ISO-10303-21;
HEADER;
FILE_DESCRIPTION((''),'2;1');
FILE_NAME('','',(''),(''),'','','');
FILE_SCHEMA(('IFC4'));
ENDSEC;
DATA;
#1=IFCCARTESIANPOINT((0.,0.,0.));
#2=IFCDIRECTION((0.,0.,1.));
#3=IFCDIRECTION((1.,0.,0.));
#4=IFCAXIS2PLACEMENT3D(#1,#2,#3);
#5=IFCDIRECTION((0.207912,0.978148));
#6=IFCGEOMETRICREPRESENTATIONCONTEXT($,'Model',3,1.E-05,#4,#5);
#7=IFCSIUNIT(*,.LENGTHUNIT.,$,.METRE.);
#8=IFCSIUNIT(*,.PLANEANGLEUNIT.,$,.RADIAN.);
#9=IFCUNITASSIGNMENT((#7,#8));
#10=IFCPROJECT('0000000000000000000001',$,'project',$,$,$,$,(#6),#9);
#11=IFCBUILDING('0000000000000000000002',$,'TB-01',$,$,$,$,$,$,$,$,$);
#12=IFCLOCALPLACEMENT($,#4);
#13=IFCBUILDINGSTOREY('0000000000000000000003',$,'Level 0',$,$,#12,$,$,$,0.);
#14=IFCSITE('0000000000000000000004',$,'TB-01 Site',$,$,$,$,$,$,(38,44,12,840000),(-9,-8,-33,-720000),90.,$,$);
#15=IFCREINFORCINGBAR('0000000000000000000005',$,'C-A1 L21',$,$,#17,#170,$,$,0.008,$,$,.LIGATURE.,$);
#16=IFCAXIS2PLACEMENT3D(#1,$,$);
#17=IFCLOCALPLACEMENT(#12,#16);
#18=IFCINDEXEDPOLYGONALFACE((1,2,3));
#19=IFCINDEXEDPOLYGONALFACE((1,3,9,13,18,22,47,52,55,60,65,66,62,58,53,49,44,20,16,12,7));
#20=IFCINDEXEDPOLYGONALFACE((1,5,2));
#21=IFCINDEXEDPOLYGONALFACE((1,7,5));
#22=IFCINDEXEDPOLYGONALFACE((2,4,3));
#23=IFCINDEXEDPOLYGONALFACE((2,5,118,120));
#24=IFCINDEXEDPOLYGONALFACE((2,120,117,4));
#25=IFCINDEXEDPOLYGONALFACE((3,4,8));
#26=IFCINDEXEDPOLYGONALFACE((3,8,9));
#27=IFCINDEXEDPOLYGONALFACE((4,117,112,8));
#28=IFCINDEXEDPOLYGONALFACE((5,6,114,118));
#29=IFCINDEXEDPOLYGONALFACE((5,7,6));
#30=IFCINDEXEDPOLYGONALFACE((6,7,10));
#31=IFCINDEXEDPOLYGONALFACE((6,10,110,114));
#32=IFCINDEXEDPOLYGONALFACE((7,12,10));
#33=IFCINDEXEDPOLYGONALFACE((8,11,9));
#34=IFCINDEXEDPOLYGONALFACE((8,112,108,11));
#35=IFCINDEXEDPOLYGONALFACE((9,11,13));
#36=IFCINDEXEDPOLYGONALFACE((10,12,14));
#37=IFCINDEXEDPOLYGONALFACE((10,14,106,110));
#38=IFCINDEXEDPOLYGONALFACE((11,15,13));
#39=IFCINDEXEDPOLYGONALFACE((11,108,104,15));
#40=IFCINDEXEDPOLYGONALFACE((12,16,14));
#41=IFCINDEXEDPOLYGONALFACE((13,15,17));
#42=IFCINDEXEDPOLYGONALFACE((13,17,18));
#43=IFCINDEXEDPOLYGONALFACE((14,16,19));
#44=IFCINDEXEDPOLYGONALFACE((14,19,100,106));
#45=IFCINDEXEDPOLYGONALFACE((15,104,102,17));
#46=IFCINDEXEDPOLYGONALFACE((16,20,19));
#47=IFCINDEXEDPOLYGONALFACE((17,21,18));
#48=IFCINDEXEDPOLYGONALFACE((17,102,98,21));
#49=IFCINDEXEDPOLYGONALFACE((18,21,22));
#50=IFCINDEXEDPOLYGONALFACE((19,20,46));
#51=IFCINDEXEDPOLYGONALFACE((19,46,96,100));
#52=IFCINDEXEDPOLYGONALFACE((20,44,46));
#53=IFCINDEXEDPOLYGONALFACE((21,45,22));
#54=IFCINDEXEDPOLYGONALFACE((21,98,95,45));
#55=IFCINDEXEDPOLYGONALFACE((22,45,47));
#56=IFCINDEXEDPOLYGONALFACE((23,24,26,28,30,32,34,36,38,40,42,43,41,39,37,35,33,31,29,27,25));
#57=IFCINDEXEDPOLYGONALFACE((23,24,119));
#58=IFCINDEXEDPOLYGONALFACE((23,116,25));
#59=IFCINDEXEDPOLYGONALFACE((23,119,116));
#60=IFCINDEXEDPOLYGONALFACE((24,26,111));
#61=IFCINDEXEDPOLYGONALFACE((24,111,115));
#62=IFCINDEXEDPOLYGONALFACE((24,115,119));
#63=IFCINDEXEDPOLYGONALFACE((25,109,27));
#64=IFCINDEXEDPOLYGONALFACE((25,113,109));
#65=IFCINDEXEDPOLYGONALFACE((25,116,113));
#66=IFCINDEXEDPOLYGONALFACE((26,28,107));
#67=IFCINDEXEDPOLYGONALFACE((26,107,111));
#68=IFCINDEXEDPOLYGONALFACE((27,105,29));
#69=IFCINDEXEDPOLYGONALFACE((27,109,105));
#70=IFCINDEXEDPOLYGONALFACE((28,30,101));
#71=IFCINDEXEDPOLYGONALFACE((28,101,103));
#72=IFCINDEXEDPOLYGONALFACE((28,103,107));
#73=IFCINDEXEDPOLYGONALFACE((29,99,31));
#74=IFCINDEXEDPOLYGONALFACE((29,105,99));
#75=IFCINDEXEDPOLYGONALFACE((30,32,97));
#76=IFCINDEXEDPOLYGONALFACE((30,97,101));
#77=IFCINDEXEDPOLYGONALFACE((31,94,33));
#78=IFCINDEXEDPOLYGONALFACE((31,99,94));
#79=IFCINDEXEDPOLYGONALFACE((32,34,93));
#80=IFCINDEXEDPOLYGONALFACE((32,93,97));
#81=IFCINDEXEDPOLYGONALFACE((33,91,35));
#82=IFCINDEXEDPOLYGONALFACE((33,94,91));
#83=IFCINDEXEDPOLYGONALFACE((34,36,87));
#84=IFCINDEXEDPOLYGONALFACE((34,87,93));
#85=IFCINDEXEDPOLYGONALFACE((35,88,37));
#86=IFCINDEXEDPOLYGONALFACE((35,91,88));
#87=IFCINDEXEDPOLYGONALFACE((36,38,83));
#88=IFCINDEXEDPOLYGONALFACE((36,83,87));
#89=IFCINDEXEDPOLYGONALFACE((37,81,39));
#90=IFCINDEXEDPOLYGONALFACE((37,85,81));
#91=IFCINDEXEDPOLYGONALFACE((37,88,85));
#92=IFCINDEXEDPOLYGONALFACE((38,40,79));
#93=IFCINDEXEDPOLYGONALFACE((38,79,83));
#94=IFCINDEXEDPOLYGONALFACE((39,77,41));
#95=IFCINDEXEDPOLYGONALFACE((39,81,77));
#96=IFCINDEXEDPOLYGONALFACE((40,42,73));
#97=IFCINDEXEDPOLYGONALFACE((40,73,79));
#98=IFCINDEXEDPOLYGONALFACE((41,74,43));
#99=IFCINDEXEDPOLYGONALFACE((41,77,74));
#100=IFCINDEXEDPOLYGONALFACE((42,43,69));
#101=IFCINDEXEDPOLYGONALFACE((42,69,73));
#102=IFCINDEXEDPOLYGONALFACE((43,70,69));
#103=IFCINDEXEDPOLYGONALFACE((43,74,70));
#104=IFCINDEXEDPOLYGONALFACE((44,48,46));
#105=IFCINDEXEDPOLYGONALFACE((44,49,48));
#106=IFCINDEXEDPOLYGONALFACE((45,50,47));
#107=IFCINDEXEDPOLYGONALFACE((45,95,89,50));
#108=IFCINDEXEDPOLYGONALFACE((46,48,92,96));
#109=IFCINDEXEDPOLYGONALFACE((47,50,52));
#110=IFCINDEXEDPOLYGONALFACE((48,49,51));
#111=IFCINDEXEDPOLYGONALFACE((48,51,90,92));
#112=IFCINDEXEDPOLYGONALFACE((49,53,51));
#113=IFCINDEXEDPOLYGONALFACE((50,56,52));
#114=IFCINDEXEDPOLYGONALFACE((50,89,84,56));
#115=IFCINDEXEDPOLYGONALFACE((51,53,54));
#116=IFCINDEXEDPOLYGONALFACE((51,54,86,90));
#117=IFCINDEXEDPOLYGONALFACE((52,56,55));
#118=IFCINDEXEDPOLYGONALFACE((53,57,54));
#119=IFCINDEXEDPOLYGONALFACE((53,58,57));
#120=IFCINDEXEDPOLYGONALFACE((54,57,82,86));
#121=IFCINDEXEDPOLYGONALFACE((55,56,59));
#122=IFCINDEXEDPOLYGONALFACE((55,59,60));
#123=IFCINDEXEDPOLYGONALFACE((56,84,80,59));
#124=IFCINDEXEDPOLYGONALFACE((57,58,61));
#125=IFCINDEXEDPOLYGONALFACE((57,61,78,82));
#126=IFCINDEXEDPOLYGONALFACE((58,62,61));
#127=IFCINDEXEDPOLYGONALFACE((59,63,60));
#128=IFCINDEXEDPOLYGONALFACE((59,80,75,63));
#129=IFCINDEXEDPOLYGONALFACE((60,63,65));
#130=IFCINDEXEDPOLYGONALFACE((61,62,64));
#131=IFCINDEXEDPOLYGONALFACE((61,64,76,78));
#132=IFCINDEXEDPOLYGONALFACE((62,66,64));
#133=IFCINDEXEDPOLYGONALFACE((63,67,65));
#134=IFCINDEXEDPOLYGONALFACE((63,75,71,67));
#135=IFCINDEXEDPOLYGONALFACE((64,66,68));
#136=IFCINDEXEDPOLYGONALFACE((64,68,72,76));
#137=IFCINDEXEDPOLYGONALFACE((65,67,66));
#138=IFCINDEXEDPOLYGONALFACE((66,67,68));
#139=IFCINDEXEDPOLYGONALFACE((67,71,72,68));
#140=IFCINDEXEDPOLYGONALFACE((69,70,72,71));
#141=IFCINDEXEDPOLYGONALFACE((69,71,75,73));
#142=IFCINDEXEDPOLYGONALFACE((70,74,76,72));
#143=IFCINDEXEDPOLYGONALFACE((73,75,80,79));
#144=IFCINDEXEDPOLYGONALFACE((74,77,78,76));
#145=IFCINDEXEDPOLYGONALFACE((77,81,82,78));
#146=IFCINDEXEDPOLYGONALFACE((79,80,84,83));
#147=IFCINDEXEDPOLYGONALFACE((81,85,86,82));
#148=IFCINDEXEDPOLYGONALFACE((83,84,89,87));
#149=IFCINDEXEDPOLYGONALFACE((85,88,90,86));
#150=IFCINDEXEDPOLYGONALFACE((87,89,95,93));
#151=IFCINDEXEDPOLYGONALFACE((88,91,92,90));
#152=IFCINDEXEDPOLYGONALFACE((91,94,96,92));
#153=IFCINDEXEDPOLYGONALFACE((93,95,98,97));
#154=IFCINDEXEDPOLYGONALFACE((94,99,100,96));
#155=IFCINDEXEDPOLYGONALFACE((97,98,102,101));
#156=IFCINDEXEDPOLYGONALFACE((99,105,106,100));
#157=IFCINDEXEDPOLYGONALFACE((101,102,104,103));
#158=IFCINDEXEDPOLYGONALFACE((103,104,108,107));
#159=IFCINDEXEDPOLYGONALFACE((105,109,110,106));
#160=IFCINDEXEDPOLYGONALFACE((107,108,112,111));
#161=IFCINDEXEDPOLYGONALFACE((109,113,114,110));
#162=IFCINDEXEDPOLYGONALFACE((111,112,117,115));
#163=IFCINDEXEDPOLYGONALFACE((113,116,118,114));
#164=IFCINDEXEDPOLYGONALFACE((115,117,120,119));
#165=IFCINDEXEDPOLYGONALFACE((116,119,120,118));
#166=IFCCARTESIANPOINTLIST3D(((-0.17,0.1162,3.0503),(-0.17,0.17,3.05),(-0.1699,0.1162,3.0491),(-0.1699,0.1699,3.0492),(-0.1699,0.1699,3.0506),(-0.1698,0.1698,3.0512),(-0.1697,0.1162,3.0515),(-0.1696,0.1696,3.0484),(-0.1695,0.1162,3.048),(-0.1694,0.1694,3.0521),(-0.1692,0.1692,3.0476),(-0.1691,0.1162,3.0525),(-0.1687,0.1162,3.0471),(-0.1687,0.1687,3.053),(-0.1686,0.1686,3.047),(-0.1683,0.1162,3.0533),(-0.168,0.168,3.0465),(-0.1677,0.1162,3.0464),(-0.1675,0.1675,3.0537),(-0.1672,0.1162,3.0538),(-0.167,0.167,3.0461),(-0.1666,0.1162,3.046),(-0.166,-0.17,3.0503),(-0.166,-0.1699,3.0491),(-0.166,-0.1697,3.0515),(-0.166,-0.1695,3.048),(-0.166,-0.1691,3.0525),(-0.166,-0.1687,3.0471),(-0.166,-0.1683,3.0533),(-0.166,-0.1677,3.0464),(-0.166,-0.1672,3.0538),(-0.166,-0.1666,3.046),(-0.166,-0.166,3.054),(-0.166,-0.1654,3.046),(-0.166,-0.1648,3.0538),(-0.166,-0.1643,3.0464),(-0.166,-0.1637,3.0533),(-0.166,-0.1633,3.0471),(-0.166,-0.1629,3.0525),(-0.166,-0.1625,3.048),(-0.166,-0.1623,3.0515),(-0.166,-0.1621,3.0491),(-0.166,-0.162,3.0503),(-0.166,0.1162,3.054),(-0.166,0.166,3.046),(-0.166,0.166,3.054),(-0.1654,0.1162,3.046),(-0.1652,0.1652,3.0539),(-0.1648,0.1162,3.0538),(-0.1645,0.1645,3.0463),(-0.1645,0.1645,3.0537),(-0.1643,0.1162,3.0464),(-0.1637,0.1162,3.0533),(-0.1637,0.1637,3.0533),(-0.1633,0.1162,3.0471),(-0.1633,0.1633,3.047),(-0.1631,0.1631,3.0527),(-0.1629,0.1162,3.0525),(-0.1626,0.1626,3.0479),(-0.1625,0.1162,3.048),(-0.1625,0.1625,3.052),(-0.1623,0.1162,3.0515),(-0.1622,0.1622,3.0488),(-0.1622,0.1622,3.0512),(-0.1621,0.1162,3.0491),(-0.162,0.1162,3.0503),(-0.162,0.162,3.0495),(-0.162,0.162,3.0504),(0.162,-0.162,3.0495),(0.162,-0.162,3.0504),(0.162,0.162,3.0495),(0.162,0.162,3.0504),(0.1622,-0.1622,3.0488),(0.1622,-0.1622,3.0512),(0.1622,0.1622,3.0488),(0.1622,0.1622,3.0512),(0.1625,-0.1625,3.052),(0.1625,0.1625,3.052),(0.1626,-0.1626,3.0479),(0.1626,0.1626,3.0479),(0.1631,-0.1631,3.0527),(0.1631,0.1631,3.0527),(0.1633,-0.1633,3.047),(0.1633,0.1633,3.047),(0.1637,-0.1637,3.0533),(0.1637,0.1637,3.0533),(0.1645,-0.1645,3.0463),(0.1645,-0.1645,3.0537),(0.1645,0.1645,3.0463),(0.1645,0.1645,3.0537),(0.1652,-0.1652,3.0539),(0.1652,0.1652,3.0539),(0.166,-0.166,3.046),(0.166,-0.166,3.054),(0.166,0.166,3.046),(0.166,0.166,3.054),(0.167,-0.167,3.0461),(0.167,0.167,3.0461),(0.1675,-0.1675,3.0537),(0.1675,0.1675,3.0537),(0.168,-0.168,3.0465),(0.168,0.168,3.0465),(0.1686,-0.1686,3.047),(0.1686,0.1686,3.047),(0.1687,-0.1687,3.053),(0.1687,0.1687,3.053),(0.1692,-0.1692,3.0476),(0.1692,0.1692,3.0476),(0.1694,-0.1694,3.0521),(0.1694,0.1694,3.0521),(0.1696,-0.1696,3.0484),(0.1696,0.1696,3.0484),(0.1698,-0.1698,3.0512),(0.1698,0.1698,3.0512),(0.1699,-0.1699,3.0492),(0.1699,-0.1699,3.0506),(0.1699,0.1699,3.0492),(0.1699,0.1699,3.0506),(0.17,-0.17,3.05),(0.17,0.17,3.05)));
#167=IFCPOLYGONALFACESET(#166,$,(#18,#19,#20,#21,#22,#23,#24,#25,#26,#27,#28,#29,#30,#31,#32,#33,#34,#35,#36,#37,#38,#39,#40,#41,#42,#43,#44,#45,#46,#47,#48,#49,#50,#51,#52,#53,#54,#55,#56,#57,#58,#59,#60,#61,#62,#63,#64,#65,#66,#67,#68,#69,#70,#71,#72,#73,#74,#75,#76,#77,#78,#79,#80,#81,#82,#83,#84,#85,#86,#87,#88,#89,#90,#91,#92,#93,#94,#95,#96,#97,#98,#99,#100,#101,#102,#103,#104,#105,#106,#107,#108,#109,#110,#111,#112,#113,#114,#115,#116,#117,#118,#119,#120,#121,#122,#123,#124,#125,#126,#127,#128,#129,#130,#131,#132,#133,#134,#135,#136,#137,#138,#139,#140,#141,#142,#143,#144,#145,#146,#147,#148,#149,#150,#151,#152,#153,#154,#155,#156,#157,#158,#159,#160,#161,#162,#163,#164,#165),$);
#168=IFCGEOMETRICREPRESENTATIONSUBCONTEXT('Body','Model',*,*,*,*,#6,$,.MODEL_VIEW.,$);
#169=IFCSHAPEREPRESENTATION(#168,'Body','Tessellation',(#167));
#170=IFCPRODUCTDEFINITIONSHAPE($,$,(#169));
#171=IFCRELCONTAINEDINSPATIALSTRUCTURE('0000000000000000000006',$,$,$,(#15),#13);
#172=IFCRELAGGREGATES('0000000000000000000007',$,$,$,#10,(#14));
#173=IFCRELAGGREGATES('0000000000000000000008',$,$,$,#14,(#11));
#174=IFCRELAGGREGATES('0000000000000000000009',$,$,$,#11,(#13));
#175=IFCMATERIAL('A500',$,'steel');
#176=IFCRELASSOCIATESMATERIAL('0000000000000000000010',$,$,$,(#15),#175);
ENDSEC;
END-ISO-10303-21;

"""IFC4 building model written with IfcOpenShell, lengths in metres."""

from ifc_helpers import new_model, entity, si_unit, direction, origin_with_axes, place, context, subcontext, project, spatial, material, element, save


model = new_model("IFC4")

# Units and contexts
model_context = context("Model", 3, precision=1e-05, world=origin_with_axes(), true_north=direction((0.207912, 0.978148)))
body_context = subcontext(model_context, "Body", "Model", "MODEL_VIEW")
ifc_project = project(units=[si_unit("LENGTHUNIT", "METRE"), si_unit("PLANEANGLEUNIT", "RADIAN")], contexts=[model_context])

# Site, building, storey
site = spatial("IfcSite", under=ifc_project, Name="TB-01 Site", RefLatitude=(38, 44, 12, 840000), RefLongitude=(-9, -8, -33, -720000), RefElevation=90.0)
building = spatial("IfcBuilding", under=site, Name="TB-01")
storey_placement = place(None, origin_with_axes())
storey = spatial("IfcBuildingStorey", under=building, at=storey_placement, Name="Level 0", Elevation=0.0)

# Reinforcing bar
ifc_material_1 = material(Name="A500", Category="steel")
reinforcing_bar_1_placement = place(storey_placement, origin_with_axes())
element("IfcReinforcingBar", 1, at=reinforcing_bar_1_placement, inside=storey, material=ifc_material_1, Name="C-A1 L21", NominalDiameter=0.008, PredefinedType="LIGATURE", context=body_context, shape_type="AdvancedSweptSolid", body=[
    entity("IfcSweptDiskSolid", entity("IfcPolyline", [entity("IfcCartesianPoint", [-0.166, -0.166, 3.05]), entity("IfcCartesianPoint", [0.166, -0.166, 3.05]), entity("IfcCartesianPoint", [0.166, 0.166, 3.05]), entity("IfcCartesianPoint", [-0.166, 0.166, 3.05]), entity("IfcCartesianPoint", [-0.166, 0.1162, 3.05])]), 0.004),
])

save(model, "model.ifc")
